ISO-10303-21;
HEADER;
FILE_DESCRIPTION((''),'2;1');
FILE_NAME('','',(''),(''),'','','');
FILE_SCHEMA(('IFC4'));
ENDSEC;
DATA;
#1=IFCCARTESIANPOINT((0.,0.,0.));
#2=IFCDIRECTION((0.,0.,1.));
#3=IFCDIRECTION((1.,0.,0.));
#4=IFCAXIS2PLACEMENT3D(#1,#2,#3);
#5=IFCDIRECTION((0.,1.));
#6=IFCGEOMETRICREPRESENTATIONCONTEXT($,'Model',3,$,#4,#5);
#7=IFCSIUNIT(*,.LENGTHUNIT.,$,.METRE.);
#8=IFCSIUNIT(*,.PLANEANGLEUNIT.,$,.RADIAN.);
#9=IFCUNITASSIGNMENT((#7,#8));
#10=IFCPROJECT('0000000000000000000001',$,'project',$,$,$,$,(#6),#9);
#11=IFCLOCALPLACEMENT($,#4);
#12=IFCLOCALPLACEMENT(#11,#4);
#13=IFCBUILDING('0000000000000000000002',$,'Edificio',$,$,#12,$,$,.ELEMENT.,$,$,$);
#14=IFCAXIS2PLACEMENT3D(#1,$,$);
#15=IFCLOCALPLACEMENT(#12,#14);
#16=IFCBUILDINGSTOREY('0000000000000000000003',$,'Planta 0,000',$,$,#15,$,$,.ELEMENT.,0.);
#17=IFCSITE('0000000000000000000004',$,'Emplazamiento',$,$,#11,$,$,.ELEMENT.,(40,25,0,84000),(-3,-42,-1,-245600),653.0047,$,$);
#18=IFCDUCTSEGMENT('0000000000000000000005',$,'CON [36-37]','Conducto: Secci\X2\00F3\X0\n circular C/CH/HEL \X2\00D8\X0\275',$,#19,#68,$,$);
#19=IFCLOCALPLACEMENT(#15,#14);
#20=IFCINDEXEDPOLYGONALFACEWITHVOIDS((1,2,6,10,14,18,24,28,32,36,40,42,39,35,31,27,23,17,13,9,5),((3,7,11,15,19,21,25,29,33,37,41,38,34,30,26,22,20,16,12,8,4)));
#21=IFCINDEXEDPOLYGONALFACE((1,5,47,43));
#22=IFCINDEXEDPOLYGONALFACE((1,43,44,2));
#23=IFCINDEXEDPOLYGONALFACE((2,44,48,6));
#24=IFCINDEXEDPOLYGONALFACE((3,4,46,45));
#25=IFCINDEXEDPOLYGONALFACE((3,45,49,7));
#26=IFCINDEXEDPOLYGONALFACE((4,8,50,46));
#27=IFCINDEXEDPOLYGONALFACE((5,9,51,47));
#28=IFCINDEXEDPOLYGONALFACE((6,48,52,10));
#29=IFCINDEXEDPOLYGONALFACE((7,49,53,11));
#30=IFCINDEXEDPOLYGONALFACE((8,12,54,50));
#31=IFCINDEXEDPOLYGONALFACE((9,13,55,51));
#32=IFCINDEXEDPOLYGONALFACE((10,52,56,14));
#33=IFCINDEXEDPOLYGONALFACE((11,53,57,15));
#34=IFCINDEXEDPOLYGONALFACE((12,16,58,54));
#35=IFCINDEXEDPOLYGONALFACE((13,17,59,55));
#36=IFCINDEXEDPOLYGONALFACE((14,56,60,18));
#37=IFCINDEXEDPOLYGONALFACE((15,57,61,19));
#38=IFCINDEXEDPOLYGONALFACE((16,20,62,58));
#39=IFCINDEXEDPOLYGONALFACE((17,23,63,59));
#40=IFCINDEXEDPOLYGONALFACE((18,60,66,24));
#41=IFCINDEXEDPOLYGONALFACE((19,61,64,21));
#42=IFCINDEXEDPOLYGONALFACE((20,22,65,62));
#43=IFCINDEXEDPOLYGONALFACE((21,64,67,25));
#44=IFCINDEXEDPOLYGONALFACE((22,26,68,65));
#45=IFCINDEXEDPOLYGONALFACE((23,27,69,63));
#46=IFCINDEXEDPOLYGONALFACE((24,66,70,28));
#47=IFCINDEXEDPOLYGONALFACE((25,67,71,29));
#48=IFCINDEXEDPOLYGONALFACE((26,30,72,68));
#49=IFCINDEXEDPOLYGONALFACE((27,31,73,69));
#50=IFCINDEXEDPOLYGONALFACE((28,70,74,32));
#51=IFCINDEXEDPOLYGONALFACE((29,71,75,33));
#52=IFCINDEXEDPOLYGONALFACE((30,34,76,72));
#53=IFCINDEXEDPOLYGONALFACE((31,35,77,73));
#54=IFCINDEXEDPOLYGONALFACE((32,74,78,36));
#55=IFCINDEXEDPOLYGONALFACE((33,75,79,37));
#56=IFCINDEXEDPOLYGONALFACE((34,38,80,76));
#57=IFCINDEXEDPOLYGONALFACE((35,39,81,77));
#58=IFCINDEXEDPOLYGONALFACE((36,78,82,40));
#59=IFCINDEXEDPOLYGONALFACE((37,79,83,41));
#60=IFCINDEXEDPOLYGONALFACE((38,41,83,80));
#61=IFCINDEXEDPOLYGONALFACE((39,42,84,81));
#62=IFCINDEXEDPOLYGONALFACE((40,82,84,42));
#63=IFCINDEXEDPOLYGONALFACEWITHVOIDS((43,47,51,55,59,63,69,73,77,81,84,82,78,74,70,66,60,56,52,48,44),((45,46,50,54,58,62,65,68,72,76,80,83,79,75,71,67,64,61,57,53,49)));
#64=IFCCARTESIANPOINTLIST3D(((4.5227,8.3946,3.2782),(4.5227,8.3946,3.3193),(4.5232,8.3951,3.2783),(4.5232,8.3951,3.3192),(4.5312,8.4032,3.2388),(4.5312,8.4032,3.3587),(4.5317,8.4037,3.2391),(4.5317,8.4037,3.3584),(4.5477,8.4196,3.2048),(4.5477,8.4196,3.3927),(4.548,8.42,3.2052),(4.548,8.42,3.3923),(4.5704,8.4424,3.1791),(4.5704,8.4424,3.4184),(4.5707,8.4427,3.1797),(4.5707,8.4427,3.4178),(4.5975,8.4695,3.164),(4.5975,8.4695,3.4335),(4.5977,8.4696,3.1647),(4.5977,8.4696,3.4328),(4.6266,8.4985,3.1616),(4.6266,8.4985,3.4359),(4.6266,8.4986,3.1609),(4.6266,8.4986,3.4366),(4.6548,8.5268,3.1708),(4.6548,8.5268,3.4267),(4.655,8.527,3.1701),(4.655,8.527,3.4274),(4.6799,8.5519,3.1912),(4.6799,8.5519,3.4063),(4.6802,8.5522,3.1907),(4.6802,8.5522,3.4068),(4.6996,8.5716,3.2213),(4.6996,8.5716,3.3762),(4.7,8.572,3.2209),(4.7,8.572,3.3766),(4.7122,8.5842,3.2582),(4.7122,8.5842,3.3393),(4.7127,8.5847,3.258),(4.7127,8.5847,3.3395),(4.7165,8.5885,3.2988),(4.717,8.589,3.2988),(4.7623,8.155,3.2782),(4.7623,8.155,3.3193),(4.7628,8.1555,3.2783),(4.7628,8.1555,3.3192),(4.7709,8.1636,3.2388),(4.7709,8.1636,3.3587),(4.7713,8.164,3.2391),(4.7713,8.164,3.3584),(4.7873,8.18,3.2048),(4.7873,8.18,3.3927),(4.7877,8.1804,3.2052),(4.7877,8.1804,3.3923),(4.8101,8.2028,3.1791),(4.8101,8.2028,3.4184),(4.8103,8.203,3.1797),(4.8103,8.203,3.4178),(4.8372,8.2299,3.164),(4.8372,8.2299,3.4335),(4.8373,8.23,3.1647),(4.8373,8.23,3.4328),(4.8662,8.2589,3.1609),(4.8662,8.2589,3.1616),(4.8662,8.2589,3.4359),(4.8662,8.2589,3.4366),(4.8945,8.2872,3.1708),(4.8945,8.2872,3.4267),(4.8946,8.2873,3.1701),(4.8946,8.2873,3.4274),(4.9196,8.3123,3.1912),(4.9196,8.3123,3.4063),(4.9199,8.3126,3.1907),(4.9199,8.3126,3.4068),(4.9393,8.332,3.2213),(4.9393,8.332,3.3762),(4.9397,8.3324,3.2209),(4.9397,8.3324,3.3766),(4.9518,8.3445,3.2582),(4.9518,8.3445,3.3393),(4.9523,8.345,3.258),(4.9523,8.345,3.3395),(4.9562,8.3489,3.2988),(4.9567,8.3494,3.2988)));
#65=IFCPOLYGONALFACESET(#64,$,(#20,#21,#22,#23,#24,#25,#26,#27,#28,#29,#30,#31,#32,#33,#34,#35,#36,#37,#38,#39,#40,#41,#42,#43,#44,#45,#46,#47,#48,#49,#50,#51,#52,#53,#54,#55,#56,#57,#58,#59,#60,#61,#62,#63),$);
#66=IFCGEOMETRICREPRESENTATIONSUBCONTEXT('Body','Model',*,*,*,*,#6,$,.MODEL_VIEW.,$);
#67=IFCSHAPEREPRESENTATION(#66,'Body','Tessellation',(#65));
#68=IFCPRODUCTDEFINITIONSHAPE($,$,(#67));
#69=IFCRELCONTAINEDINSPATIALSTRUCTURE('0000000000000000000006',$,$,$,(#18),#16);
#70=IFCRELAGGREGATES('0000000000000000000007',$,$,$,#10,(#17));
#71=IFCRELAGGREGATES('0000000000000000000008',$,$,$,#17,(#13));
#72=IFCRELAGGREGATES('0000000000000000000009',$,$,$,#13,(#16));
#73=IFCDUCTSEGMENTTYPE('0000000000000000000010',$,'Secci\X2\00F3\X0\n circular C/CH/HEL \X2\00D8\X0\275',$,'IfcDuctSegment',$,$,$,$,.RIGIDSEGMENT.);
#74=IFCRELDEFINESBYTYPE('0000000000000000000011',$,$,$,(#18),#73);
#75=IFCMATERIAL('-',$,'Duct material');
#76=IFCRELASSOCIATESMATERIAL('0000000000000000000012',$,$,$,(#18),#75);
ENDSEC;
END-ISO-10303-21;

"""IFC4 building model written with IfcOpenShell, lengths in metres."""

from ifc_helpers import new_model, si_unit, direction, frame, origin, origin_with_axes, origin_2d_with_axis, place, context, subcontext, project, spatial, hollow_circle, extrude, material, type_object, element, save


model = new_model("IFC4")

# Units and contexts
model_context = context("Model", 3, world=origin_with_axes(), true_north=direction((0.0, 1.0)))
body_context = subcontext(model_context, "Body", "Model", "MODEL_VIEW")
ifc_project = project(units=[si_unit("LENGTHUNIT", "METRE"), si_unit("PLANEANGLEUNIT", "RADIAN")], contexts=[model_context])

# Site, building, storey
site_placement = place(None, origin_with_axes())
site = spatial("IfcSite", under=ifc_project, at=site_placement, Name="Emplazamiento", CompositionType="ELEMENT", RefLatitude=(40, 25, 0, 84000), RefLongitude=(-3, -42, -1, -245600), RefElevation=653.0047)
building_placement = place(site_placement, origin_with_axes())
building = spatial("IfcBuilding", under=site, at=building_placement, Name="Edificio", CompositionType="ELEMENT")
storey_placement = place(building_placement, origin())
storey = spatial("IfcBuildingStorey", under=building, at=storey_placement, Name="Planta 0,000", CompositionType="ELEMENT", Elevation=0.0)

# Shared definitions
ifc_material_1 = material(Name="-", Category="Duct material")

# Duct segment
duct_segment_type_1 = type_object("IfcDuctSegmentType", Name="Sección circular C/CH/HEL Ø275", ApplicableOccurrence="IfcDuctSegment", PredefinedType="RIGIDSEGMENT")
duct_segment_1_placement = place(storey_placement, origin_with_axes())
element("IfcDuctSegment", 1, at=duct_segment_1_placement, inside=storey, type_object=duct_segment_type_1, material=ifc_material_1, Name="CON [36-37]", Description="Conducto: Sección circular C/CH/HEL Ø275", context=body_context, shape_type="SweptSolid", body=[
    extrude(hollow_circle(Radius=0.1382, WallThickness=0.0007, at=origin_2d_with_axis()), frame((4.6193, 8.4913, 3.2988), z_axis=(0.707107, -0.707107, 0.0), x_axis=(0.707107, 0.707107, 0.0)), (0.0, 0.0, 1.0), 0.3389),
])

save(model, "model.ifc")
